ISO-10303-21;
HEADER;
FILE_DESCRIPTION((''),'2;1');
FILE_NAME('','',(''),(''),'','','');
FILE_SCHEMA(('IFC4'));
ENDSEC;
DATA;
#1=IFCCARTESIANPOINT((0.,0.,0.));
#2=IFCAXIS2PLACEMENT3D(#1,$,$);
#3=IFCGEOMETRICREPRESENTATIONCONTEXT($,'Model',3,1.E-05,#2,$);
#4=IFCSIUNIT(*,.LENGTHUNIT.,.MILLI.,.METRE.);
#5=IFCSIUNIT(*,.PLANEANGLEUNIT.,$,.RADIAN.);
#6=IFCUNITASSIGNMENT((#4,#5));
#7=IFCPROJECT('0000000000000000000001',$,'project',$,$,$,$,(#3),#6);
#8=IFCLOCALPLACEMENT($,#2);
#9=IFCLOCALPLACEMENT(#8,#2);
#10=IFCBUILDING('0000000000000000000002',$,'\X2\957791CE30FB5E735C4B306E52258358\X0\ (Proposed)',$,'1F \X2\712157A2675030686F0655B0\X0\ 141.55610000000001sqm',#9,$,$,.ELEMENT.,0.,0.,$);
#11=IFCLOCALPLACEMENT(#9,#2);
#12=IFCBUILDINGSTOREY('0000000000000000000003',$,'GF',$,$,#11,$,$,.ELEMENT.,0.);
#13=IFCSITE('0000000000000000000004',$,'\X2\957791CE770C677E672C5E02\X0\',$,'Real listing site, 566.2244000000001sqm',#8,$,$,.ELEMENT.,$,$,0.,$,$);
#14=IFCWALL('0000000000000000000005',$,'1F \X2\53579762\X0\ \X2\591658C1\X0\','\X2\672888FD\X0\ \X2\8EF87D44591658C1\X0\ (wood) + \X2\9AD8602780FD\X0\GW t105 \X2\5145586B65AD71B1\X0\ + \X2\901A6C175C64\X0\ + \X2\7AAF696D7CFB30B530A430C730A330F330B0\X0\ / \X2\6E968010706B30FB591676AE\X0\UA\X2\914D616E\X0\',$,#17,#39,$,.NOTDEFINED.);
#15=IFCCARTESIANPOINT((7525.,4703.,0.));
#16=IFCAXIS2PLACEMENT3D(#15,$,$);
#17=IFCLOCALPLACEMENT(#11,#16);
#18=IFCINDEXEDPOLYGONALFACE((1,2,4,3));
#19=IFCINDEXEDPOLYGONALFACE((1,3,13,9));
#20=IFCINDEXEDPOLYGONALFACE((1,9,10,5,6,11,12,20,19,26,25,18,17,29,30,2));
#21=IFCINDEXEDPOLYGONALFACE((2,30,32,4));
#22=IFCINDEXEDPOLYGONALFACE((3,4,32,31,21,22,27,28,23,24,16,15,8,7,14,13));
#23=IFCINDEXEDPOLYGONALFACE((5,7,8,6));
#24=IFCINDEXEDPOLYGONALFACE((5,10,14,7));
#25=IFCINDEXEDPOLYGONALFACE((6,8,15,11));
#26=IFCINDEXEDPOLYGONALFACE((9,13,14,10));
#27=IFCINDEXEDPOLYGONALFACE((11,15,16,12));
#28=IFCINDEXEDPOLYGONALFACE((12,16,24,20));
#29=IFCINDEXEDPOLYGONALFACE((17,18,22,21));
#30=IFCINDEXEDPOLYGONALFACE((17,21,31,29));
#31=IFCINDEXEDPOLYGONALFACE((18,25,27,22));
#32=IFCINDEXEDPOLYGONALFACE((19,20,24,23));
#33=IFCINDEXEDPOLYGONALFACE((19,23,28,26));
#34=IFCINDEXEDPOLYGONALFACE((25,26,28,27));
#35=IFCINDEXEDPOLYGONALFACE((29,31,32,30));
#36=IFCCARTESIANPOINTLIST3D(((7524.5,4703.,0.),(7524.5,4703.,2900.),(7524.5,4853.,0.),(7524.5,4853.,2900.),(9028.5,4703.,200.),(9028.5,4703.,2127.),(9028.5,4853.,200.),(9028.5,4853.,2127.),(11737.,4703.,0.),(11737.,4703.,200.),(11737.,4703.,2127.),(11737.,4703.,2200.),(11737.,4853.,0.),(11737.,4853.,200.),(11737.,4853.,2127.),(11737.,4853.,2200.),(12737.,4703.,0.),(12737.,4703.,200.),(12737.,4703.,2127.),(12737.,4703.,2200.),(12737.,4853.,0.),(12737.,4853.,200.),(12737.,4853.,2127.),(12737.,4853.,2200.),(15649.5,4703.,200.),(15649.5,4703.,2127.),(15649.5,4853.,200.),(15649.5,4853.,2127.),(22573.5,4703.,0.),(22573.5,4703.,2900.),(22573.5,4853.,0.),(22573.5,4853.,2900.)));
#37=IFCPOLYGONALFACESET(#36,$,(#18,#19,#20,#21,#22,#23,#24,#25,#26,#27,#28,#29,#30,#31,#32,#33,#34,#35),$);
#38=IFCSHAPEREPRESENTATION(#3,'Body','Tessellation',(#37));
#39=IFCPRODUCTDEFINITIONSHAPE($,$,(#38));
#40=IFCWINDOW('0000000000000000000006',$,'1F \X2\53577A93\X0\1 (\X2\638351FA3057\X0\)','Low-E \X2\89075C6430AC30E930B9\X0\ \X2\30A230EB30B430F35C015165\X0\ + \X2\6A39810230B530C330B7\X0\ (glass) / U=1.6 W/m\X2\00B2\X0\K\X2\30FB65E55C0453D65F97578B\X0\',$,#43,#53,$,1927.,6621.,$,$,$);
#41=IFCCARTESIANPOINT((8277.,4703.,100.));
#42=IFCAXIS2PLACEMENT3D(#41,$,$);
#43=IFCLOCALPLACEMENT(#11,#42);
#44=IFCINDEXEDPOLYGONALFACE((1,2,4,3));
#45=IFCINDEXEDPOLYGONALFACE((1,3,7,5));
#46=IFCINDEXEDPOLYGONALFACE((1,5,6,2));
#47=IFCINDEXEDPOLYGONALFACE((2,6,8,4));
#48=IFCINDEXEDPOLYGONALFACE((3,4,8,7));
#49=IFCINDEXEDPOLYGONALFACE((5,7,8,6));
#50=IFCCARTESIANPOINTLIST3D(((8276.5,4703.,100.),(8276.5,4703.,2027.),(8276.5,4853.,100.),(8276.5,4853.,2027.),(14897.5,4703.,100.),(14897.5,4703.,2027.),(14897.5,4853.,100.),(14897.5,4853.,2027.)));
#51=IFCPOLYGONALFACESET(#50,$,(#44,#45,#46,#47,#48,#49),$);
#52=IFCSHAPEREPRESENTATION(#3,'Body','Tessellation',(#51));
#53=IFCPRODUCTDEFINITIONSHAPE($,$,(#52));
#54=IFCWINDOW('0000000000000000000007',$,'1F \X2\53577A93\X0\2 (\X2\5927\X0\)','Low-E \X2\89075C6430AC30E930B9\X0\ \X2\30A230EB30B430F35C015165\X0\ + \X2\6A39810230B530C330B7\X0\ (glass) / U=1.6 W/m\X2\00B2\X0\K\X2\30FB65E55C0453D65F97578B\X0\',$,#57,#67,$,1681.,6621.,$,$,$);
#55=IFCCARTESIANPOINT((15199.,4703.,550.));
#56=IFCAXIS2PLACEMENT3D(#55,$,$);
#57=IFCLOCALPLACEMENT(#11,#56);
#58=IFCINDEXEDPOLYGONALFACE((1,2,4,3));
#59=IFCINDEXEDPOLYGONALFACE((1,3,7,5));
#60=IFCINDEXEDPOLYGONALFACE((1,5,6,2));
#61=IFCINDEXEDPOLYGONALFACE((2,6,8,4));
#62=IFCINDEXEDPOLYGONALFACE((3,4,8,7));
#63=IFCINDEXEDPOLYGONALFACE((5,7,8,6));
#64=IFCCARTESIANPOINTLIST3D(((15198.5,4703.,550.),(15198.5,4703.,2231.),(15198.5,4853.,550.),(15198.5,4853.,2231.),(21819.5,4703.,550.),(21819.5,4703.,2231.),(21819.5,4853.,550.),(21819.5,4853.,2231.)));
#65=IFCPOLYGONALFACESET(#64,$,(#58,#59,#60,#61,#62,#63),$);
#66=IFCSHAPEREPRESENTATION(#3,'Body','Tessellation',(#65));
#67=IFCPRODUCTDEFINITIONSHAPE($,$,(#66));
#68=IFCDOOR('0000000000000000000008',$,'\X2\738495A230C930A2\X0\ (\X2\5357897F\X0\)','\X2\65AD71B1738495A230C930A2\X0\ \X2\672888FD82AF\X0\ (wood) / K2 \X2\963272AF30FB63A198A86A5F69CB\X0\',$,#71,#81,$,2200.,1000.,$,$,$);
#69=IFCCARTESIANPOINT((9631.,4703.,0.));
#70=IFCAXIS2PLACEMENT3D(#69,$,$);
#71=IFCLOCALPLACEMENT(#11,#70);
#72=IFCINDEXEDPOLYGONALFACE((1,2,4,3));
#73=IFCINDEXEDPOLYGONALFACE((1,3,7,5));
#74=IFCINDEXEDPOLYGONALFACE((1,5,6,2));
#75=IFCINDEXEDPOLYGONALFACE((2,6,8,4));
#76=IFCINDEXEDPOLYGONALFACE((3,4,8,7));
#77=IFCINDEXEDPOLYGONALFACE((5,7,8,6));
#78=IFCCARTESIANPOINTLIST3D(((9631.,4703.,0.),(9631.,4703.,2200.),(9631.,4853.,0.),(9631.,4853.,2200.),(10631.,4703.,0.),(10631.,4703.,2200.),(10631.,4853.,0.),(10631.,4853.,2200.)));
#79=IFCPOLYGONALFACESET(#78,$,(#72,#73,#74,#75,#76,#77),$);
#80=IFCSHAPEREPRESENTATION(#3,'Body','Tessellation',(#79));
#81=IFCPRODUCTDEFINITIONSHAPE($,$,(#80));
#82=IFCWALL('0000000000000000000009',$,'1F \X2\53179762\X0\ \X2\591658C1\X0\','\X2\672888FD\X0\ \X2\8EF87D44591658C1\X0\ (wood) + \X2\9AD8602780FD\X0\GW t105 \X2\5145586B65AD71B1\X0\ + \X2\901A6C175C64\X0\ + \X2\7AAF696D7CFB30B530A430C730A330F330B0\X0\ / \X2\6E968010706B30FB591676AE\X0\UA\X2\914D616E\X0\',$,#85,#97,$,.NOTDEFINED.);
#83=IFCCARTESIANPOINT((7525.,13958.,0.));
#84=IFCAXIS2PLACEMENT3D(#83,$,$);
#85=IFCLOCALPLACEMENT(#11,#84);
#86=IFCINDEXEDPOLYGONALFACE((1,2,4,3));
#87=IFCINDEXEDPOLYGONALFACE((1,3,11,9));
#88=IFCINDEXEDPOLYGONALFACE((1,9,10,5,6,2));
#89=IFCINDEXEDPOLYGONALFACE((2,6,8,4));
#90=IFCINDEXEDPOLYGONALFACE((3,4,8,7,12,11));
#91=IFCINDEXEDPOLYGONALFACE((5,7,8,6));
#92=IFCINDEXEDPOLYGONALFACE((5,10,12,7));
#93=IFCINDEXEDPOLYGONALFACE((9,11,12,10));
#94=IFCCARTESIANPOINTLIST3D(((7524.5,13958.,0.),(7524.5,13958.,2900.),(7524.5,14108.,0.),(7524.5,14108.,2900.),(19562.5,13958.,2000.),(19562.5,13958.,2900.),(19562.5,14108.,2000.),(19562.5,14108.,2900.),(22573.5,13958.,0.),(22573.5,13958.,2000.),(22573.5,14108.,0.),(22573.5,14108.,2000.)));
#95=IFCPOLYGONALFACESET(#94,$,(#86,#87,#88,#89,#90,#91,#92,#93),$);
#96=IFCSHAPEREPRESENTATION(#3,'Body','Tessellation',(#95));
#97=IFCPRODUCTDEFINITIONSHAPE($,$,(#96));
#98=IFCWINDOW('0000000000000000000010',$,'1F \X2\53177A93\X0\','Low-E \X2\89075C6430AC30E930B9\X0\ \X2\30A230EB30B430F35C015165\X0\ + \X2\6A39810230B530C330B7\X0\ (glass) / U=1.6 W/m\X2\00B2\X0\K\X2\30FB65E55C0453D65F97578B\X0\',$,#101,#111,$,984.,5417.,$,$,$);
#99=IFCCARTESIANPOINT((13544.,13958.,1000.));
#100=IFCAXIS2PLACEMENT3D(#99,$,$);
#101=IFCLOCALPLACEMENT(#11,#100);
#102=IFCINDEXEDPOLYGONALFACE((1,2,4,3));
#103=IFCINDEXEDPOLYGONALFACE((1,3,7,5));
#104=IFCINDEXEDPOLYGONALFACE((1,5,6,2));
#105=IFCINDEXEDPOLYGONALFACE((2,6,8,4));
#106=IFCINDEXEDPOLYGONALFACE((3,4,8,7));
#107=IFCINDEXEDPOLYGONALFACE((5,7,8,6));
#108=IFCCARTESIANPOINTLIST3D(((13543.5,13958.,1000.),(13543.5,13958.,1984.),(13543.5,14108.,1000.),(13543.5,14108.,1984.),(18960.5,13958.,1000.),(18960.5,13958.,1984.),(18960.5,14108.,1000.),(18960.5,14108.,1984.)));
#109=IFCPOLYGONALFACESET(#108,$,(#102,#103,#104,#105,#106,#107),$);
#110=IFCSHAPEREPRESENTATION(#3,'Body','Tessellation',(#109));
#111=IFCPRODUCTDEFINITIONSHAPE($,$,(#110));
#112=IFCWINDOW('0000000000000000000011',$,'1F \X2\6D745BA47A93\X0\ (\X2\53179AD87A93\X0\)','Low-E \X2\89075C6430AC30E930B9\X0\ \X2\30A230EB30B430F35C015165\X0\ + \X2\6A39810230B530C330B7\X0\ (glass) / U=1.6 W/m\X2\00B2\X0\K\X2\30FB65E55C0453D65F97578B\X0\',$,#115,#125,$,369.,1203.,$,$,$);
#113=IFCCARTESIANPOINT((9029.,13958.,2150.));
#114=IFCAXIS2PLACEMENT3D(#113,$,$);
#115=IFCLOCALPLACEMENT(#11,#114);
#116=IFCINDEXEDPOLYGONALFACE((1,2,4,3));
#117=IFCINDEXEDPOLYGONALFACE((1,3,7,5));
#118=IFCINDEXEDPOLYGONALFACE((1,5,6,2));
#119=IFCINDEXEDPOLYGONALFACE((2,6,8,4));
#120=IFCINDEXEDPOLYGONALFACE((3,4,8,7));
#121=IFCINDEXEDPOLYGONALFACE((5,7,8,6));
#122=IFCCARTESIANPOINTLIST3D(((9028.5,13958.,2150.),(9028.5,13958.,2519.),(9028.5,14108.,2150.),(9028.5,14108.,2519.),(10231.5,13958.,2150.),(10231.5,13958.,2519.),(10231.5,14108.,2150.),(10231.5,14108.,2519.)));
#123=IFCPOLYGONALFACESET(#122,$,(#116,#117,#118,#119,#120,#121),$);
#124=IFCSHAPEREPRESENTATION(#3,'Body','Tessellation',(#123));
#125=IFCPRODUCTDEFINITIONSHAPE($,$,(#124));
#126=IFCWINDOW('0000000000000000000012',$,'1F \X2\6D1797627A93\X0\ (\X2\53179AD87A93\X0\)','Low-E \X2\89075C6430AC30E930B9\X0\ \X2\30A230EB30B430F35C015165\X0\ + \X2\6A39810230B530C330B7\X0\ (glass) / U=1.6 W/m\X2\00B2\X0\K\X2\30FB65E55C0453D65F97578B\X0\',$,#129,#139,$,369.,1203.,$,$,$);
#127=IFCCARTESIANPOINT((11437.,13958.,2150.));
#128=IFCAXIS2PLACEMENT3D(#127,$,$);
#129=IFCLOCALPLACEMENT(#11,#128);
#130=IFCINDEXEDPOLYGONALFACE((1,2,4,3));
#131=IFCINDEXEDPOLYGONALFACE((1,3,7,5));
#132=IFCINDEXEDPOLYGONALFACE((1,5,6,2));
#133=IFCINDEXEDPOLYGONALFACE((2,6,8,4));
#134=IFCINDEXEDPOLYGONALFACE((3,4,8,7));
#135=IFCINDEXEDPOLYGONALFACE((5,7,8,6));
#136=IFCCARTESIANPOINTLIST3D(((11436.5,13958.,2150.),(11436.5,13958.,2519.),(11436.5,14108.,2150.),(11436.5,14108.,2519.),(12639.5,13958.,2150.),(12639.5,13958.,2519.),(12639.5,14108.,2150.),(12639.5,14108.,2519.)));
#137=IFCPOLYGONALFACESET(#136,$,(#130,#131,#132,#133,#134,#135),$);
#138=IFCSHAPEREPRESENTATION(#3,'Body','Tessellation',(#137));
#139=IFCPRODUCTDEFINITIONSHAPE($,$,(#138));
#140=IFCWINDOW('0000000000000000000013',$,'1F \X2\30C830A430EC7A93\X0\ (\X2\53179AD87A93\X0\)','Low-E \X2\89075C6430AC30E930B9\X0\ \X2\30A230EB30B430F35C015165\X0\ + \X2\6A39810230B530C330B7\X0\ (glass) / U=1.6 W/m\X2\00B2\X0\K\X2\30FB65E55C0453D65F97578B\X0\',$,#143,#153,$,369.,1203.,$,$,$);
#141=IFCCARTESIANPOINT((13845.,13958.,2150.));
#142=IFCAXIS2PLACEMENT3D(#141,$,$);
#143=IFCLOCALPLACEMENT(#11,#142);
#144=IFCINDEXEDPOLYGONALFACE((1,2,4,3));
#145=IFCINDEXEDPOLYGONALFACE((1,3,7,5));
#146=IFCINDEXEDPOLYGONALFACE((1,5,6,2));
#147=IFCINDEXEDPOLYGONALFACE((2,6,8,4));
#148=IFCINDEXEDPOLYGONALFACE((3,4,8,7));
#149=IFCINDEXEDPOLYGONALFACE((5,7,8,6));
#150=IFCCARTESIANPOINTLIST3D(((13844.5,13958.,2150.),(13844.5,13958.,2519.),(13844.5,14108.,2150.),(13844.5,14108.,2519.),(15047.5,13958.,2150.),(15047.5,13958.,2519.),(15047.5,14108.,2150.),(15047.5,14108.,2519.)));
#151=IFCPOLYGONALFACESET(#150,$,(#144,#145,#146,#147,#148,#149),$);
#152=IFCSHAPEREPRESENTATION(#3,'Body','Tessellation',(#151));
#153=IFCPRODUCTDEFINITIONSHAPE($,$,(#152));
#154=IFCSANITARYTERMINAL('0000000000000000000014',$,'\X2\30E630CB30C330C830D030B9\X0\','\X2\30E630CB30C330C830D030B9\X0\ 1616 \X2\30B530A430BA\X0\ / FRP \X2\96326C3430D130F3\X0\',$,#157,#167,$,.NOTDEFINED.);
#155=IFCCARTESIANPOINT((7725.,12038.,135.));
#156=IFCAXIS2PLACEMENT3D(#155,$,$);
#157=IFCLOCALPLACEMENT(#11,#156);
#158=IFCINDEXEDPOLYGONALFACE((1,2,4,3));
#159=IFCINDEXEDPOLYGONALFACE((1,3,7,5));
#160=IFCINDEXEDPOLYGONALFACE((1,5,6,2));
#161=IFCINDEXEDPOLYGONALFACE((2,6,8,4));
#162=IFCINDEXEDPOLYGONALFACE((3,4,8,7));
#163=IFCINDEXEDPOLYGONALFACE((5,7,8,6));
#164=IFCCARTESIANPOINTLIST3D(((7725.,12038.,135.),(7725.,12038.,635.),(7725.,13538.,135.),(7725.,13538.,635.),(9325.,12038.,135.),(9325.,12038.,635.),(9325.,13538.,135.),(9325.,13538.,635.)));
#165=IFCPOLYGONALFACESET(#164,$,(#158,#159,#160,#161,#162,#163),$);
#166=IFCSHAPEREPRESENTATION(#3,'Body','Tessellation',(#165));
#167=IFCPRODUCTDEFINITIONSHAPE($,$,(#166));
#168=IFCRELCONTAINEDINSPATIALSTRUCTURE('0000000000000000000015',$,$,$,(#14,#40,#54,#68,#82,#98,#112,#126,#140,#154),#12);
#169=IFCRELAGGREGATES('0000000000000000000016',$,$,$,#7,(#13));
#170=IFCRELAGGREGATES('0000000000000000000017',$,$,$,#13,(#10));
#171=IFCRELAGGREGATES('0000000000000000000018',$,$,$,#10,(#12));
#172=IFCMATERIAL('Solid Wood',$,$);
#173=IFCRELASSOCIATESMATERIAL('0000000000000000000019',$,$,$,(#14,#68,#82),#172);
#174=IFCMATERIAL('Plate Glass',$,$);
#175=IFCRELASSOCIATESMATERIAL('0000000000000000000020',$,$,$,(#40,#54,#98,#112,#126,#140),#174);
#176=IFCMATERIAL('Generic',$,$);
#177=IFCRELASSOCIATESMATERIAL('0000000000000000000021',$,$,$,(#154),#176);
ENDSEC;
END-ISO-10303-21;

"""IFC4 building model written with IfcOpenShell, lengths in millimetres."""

from ifc_helpers import new_model, si_unit, frame, frame_2d, origin, place, context, project, spatial, rectangle, extrude, material, element, fill, save


model = new_model("IFC4")

# Units and contexts
model_context = context("Model", 3, precision=1e-05, world=origin())
ifc_project = project(units=[si_unit("LENGTHUNIT", "METRE", prefix="MILLI"), si_unit("PLANEANGLEUNIT", "RADIAN")], contexts=[model_context])

# Site, building, storey
site_placement = place(None, origin())
site = spatial("IfcSite", under=ifc_project, at=site_placement, Name="長野県松本市", ObjectType="Real listing site, 566.2244000000001sqm", CompositionType="ELEMENT", RefElevation=0.0)
building_placement = place(site_placement, origin())
building = spatial("IfcBuilding", under=site, at=building_placement, Name="長野・平屋の別荘 (Proposed)", ObjectType="1F 無垢材と漆喰 141.55610000000001sqm", CompositionType="ELEMENT", ElevationOfRefHeight=0.0, ElevationOfTerrain=0.0)
storey_placement = place(building_placement, origin())
storey = spatial("IfcBuildingStorey", under=building, at=storey_placement, Name="GF", CompositionType="ELEMENT", Elevation=0.0)

# Shared definitions
ifc_material_1 = material(Name="Solid Wood")

# Wall, openings, windows, door
wall_1_placement = place(storey_placement, frame((7525.0, 4703.0, 0.0)))
wall_1 = element("IfcWall", 1, at=wall_1_placement, inside=storey, material=ifc_material_1, Name="1F 南面 外壁", Description="木製 軸組外壁 (wood) + 高性能GW t105 充填断熱 + 通気層 + 窯業系サイディング / 準耐火・外皮UA配慮", PredefinedType="NOTDEFINED", context=model_context, shape_type="SweptSolid", body=[
    extrude(rectangle(XDim=15049.0, YDim=150.0, at=frame_2d((7524.0, 75.0))), frame((7525.0, 4703.0, 0.0)), (0.0, 0.0, 1.0), 2900.0),
])
opening_1_placement = place(storey_placement, frame((8277.0, 4703.0, 100.0)))
opening_1 = element("IfcOpeningElement", 2, at=opening_1_placement, cuts=wall_1, PredefinedType="NOTDEFINED", context=model_context, shape_type="SweptSolid", body=[
    extrude(rectangle(XDim=6621.0, YDim=150.0, at=frame_2d((3310.0, 75.0))), frame((8277.0, 4703.0, 100.0)), (0.0, 0.0, 1.0), 1927.0),
])
opening_2_placement = place(storey_placement, frame((15199.0, 4703.0, 550.0)))
opening_2 = element("IfcOpeningElement", 3, at=opening_2_placement, cuts=wall_1, PredefinedType="NOTDEFINED", context=model_context, shape_type="SweptSolid", body=[
    extrude(rectangle(XDim=6621.0, YDim=150.0, at=frame_2d((3310.0, 75.0))), frame((15199.0, 4703.0, 550.0)), (0.0, 0.0, 1.0), 1681.0),
])
opening_3_placement = place(storey_placement, frame((9631.0, 4703.0, 0.0)))
opening_3 = element("IfcOpeningElement", 4, at=opening_3_placement, cuts=wall_1, PredefinedType="NOTDEFINED", context=model_context, shape_type="SweptSolid", body=[
    extrude(rectangle(XDim=1000.0, YDim=150.0, at=frame_2d((500.0, 75.0))), frame((9631.0, 4703.0, 0.0)), (0.0, 0.0, 1.0), 2200.0),
])
ifc_material_2 = material(Name="Plate Glass")
window_1_placement = place(storey_placement, frame((8277.0, 4703.0, 100.0)))
window_1 = element("IfcWindow", 5, at=window_1_placement, inside=storey, material=ifc_material_2, Name="1F 南窓1 (掃出し)", Description="Low-E 複層ガラス アルゴン封入 + 樹脂サッシ (glass) / U=1.6 W/m²K・日射取得型", OverallHeight=1927.0, OverallWidth=6621.0, context=model_context, shape_type="SweptSolid", body=[
    extrude(rectangle(XDim=6621.0, YDim=150.0, at=frame_2d((3310.0, 75.0))), frame((8277.0, 4703.0, 100.0)), (0.0, 0.0, 1.0), 1927.0),
])
fill(opening_1, window_1)
window_2_placement = place(storey_placement, frame((15199.0, 4703.0, 550.0)))
window_2 = element("IfcWindow", 6, at=window_2_placement, inside=storey, material=ifc_material_2, Name="1F 南窓2 (大)", Description="Low-E 複層ガラス アルゴン封入 + 樹脂サッシ (glass) / U=1.6 W/m²K・日射取得型", OverallHeight=1681.0, OverallWidth=6621.0, context=model_context, shape_type="SweptSolid", body=[
    extrude(rectangle(XDim=6621.0, YDim=150.0, at=frame_2d((3310.0, 75.0))), frame((15199.0, 4703.0, 550.0)), (0.0, 0.0, 1.0), 1681.0),
])
fill(opening_2, window_2)
door_1_placement = place(storey_placement, frame((9631.0, 4703.0, 0.0)))
door_1 = element("IfcDoor", 7, at=door_1_placement, inside=storey, material=ifc_material_1, Name="玄関ドア (南西)", Description="断熱玄関ドア 木製芯 (wood) / K2 防犯・採風機構", OverallHeight=2200.0, OverallWidth=1000.0, context=model_context, shape_type="SweptSolid", body=[
    extrude(rectangle(XDim=1000.0, YDim=150.0, at=frame_2d((500.0, 75.0))), frame((9631.0, 4703.0, 0.0)), (0.0, 0.0, 1.0), 2200.0),
])
fill(opening_3, door_1)

# Wall, openings, windows
wall_2_placement = place(storey_placement, frame((7525.0, 13958.0, 0.0)))
wall_2 = element("IfcWall", 8, at=wall_2_placement, inside=storey, material=ifc_material_1, Name="1F 北面 外壁", Description="木製 軸組外壁 (wood) + 高性能GW t105 充填断熱 + 通気層 + 窯業系サイディング / 準耐火・外皮UA配慮", PredefinedType="NOTDEFINED", context=model_context, shape_type="SweptSolid", body=[
    extrude(rectangle(XDim=15049.0, YDim=150.0, at=frame_2d((7524.0, 75.0))), frame((7525.0, 13958.0, 0.0)), (0.0, 0.0, 1.0), 2900.0),
])
opening_4_placement = place(storey_placement, frame((13544.0, 13958.0, 1000.0)))
opening_4 = element("IfcOpeningElement", 9, at=opening_4_placement, cuts=wall_2, PredefinedType="NOTDEFINED", context=model_context, shape_type="SweptSolid", body=[
    extrude(rectangle(XDim=5417.0, YDim=150.0, at=frame_2d((2708.0, 75.0))), frame((13544.0, 13958.0, 1000.0)), (0.0, 0.0, 1.0), 984.0),
])
opening_5_placement = place(storey_placement, frame((9029.0, 13958.0, 2150.0)))
opening_5 = element("IfcOpeningElement", 10, at=opening_5_placement, cuts=wall_2, PredefinedType="NOTDEFINED", context=model_context, shape_type="SweptSolid", body=[
    extrude(rectangle(XDim=1203.0, YDim=150.0, at=frame_2d((601.0, 75.0))), frame((9029.0, 13958.0, 2150.0)), (0.0, 0.0, 1.0), 369.0),
])
opening_6_placement = place(storey_placement, frame((11437.0, 13958.0, 2150.0)))
opening_6 = element("IfcOpeningElement", 11, at=opening_6_placement, cuts=wall_2, PredefinedType="NOTDEFINED", context=model_context, shape_type="SweptSolid", body=[
    extrude(rectangle(XDim=1203.0, YDim=150.0, at=frame_2d((601.0, 75.0))), frame((11437.0, 13958.0, 2150.0)), (0.0, 0.0, 1.0), 369.0),
])
opening_7_placement = place(storey_placement, frame((13845.0, 13958.0, 2150.0)))
opening_7 = element("IfcOpeningElement", 12, at=opening_7_placement, cuts=wall_2, PredefinedType="NOTDEFINED", context=model_context, shape_type="SweptSolid", body=[
    extrude(rectangle(XDim=1203.0, YDim=150.0, at=frame_2d((601.0, 75.0))), frame((13845.0, 13958.0, 2150.0)), (0.0, 0.0, 1.0), 369.0),
])
window_3_placement = place(storey_placement, frame((13544.0, 13958.0, 1000.0)))
window_3 = element("IfcWindow", 13, at=window_3_placement, inside=storey, material=ifc_material_2, Name="1F 北窓", Description="Low-E 複層ガラス アルゴン封入 + 樹脂サッシ (glass) / U=1.6 W/m²K・日射取得型", OverallHeight=984.0, OverallWidth=5417.0, context=model_context, shape_type="SweptSolid", body=[
    extrude(rectangle(XDim=5417.0, YDim=150.0, at=frame_2d((2708.0, 75.0))), frame((13544.0, 13958.0, 1000.0)), (0.0, 0.0, 1.0), 984.0),
])
fill(opening_4, window_3)
window_4_placement = place(storey_placement, frame((9029.0, 13958.0, 2150.0)))
window_4 = element("IfcWindow", 14, at=window_4_placement, inside=storey, material=ifc_material_2, Name="1F 浴室窓 (北高窓)", Description="Low-E 複層ガラス アルゴン封入 + 樹脂サッシ (glass) / U=1.6 W/m²K・日射取得型", OverallHeight=369.0, OverallWidth=1203.0, context=model_context, shape_type="SweptSolid", body=[
    extrude(rectangle(XDim=1203.0, YDim=150.0, at=frame_2d((601.0, 75.0))), frame((9029.0, 13958.0, 2150.0)), (0.0, 0.0, 1.0), 369.0),
])
fill(opening_5, window_4)
window_5_placement = place(storey_placement, frame((11437.0, 13958.0, 2150.0)))
window_5 = element("IfcWindow", 15, at=window_5_placement, inside=storey, material=ifc_material_2, Name="1F 洗面窓 (北高窓)", Description="Low-E 複層ガラス アルゴン封入 + 樹脂サッシ (glass) / U=1.6 W/m²K・日射取得型", OverallHeight=369.0, OverallWidth=1203.0, context=model_context, shape_type="SweptSolid", body=[
    extrude(rectangle(XDim=1203.0, YDim=150.0, at=frame_2d((601.0, 75.0))), frame((11437.0, 13958.0, 2150.0)), (0.0, 0.0, 1.0), 369.0),
])
fill(opening_6, window_5)
window_6_placement = place(storey_placement, frame((13845.0, 13958.0, 2150.0)))
window_6 = element("IfcWindow", 16, at=window_6_placement, inside=storey, material=ifc_material_2, Name="1F トイレ窓 (北高窓)", Description="Low-E 複層ガラス アルゴン封入 + 樹脂サッシ (glass) / U=1.6 W/m²K・日射取得型", OverallHeight=369.0, OverallWidth=1203.0, context=model_context, shape_type="SweptSolid", body=[
    extrude(rectangle(XDim=1203.0, YDim=150.0, at=frame_2d((601.0, 75.0))), frame((13845.0, 13958.0, 2150.0)), (0.0, 0.0, 1.0), 369.0),
])
fill(opening_7, window_6)

# Shared definitions
ifc_material_3 = material(Name="Generic")

# Sanitary terminal
sanitary_terminal_placement = place(storey_placement, frame((7725.0, 12038.0, 135.0)))
element("IfcSanitaryTerminal", 17, at=sanitary_terminal_placement, inside=storey, material=ifc_material_3, Name="ユニットバス", Description="ユニットバス 1616 サイズ / FRP 防水パン", PredefinedType="NOTDEFINED", context=model_context, shape_type="SweptSolid", body=[
    extrude(rectangle(XDim=1600.0, YDim=1500.0, at=frame_2d((800.0, 750.0))), frame((7725.0, 12038.0, 135.0)), (0.0, 0.0, 1.0), 500.0),
])

save(model, "model.ifc")
